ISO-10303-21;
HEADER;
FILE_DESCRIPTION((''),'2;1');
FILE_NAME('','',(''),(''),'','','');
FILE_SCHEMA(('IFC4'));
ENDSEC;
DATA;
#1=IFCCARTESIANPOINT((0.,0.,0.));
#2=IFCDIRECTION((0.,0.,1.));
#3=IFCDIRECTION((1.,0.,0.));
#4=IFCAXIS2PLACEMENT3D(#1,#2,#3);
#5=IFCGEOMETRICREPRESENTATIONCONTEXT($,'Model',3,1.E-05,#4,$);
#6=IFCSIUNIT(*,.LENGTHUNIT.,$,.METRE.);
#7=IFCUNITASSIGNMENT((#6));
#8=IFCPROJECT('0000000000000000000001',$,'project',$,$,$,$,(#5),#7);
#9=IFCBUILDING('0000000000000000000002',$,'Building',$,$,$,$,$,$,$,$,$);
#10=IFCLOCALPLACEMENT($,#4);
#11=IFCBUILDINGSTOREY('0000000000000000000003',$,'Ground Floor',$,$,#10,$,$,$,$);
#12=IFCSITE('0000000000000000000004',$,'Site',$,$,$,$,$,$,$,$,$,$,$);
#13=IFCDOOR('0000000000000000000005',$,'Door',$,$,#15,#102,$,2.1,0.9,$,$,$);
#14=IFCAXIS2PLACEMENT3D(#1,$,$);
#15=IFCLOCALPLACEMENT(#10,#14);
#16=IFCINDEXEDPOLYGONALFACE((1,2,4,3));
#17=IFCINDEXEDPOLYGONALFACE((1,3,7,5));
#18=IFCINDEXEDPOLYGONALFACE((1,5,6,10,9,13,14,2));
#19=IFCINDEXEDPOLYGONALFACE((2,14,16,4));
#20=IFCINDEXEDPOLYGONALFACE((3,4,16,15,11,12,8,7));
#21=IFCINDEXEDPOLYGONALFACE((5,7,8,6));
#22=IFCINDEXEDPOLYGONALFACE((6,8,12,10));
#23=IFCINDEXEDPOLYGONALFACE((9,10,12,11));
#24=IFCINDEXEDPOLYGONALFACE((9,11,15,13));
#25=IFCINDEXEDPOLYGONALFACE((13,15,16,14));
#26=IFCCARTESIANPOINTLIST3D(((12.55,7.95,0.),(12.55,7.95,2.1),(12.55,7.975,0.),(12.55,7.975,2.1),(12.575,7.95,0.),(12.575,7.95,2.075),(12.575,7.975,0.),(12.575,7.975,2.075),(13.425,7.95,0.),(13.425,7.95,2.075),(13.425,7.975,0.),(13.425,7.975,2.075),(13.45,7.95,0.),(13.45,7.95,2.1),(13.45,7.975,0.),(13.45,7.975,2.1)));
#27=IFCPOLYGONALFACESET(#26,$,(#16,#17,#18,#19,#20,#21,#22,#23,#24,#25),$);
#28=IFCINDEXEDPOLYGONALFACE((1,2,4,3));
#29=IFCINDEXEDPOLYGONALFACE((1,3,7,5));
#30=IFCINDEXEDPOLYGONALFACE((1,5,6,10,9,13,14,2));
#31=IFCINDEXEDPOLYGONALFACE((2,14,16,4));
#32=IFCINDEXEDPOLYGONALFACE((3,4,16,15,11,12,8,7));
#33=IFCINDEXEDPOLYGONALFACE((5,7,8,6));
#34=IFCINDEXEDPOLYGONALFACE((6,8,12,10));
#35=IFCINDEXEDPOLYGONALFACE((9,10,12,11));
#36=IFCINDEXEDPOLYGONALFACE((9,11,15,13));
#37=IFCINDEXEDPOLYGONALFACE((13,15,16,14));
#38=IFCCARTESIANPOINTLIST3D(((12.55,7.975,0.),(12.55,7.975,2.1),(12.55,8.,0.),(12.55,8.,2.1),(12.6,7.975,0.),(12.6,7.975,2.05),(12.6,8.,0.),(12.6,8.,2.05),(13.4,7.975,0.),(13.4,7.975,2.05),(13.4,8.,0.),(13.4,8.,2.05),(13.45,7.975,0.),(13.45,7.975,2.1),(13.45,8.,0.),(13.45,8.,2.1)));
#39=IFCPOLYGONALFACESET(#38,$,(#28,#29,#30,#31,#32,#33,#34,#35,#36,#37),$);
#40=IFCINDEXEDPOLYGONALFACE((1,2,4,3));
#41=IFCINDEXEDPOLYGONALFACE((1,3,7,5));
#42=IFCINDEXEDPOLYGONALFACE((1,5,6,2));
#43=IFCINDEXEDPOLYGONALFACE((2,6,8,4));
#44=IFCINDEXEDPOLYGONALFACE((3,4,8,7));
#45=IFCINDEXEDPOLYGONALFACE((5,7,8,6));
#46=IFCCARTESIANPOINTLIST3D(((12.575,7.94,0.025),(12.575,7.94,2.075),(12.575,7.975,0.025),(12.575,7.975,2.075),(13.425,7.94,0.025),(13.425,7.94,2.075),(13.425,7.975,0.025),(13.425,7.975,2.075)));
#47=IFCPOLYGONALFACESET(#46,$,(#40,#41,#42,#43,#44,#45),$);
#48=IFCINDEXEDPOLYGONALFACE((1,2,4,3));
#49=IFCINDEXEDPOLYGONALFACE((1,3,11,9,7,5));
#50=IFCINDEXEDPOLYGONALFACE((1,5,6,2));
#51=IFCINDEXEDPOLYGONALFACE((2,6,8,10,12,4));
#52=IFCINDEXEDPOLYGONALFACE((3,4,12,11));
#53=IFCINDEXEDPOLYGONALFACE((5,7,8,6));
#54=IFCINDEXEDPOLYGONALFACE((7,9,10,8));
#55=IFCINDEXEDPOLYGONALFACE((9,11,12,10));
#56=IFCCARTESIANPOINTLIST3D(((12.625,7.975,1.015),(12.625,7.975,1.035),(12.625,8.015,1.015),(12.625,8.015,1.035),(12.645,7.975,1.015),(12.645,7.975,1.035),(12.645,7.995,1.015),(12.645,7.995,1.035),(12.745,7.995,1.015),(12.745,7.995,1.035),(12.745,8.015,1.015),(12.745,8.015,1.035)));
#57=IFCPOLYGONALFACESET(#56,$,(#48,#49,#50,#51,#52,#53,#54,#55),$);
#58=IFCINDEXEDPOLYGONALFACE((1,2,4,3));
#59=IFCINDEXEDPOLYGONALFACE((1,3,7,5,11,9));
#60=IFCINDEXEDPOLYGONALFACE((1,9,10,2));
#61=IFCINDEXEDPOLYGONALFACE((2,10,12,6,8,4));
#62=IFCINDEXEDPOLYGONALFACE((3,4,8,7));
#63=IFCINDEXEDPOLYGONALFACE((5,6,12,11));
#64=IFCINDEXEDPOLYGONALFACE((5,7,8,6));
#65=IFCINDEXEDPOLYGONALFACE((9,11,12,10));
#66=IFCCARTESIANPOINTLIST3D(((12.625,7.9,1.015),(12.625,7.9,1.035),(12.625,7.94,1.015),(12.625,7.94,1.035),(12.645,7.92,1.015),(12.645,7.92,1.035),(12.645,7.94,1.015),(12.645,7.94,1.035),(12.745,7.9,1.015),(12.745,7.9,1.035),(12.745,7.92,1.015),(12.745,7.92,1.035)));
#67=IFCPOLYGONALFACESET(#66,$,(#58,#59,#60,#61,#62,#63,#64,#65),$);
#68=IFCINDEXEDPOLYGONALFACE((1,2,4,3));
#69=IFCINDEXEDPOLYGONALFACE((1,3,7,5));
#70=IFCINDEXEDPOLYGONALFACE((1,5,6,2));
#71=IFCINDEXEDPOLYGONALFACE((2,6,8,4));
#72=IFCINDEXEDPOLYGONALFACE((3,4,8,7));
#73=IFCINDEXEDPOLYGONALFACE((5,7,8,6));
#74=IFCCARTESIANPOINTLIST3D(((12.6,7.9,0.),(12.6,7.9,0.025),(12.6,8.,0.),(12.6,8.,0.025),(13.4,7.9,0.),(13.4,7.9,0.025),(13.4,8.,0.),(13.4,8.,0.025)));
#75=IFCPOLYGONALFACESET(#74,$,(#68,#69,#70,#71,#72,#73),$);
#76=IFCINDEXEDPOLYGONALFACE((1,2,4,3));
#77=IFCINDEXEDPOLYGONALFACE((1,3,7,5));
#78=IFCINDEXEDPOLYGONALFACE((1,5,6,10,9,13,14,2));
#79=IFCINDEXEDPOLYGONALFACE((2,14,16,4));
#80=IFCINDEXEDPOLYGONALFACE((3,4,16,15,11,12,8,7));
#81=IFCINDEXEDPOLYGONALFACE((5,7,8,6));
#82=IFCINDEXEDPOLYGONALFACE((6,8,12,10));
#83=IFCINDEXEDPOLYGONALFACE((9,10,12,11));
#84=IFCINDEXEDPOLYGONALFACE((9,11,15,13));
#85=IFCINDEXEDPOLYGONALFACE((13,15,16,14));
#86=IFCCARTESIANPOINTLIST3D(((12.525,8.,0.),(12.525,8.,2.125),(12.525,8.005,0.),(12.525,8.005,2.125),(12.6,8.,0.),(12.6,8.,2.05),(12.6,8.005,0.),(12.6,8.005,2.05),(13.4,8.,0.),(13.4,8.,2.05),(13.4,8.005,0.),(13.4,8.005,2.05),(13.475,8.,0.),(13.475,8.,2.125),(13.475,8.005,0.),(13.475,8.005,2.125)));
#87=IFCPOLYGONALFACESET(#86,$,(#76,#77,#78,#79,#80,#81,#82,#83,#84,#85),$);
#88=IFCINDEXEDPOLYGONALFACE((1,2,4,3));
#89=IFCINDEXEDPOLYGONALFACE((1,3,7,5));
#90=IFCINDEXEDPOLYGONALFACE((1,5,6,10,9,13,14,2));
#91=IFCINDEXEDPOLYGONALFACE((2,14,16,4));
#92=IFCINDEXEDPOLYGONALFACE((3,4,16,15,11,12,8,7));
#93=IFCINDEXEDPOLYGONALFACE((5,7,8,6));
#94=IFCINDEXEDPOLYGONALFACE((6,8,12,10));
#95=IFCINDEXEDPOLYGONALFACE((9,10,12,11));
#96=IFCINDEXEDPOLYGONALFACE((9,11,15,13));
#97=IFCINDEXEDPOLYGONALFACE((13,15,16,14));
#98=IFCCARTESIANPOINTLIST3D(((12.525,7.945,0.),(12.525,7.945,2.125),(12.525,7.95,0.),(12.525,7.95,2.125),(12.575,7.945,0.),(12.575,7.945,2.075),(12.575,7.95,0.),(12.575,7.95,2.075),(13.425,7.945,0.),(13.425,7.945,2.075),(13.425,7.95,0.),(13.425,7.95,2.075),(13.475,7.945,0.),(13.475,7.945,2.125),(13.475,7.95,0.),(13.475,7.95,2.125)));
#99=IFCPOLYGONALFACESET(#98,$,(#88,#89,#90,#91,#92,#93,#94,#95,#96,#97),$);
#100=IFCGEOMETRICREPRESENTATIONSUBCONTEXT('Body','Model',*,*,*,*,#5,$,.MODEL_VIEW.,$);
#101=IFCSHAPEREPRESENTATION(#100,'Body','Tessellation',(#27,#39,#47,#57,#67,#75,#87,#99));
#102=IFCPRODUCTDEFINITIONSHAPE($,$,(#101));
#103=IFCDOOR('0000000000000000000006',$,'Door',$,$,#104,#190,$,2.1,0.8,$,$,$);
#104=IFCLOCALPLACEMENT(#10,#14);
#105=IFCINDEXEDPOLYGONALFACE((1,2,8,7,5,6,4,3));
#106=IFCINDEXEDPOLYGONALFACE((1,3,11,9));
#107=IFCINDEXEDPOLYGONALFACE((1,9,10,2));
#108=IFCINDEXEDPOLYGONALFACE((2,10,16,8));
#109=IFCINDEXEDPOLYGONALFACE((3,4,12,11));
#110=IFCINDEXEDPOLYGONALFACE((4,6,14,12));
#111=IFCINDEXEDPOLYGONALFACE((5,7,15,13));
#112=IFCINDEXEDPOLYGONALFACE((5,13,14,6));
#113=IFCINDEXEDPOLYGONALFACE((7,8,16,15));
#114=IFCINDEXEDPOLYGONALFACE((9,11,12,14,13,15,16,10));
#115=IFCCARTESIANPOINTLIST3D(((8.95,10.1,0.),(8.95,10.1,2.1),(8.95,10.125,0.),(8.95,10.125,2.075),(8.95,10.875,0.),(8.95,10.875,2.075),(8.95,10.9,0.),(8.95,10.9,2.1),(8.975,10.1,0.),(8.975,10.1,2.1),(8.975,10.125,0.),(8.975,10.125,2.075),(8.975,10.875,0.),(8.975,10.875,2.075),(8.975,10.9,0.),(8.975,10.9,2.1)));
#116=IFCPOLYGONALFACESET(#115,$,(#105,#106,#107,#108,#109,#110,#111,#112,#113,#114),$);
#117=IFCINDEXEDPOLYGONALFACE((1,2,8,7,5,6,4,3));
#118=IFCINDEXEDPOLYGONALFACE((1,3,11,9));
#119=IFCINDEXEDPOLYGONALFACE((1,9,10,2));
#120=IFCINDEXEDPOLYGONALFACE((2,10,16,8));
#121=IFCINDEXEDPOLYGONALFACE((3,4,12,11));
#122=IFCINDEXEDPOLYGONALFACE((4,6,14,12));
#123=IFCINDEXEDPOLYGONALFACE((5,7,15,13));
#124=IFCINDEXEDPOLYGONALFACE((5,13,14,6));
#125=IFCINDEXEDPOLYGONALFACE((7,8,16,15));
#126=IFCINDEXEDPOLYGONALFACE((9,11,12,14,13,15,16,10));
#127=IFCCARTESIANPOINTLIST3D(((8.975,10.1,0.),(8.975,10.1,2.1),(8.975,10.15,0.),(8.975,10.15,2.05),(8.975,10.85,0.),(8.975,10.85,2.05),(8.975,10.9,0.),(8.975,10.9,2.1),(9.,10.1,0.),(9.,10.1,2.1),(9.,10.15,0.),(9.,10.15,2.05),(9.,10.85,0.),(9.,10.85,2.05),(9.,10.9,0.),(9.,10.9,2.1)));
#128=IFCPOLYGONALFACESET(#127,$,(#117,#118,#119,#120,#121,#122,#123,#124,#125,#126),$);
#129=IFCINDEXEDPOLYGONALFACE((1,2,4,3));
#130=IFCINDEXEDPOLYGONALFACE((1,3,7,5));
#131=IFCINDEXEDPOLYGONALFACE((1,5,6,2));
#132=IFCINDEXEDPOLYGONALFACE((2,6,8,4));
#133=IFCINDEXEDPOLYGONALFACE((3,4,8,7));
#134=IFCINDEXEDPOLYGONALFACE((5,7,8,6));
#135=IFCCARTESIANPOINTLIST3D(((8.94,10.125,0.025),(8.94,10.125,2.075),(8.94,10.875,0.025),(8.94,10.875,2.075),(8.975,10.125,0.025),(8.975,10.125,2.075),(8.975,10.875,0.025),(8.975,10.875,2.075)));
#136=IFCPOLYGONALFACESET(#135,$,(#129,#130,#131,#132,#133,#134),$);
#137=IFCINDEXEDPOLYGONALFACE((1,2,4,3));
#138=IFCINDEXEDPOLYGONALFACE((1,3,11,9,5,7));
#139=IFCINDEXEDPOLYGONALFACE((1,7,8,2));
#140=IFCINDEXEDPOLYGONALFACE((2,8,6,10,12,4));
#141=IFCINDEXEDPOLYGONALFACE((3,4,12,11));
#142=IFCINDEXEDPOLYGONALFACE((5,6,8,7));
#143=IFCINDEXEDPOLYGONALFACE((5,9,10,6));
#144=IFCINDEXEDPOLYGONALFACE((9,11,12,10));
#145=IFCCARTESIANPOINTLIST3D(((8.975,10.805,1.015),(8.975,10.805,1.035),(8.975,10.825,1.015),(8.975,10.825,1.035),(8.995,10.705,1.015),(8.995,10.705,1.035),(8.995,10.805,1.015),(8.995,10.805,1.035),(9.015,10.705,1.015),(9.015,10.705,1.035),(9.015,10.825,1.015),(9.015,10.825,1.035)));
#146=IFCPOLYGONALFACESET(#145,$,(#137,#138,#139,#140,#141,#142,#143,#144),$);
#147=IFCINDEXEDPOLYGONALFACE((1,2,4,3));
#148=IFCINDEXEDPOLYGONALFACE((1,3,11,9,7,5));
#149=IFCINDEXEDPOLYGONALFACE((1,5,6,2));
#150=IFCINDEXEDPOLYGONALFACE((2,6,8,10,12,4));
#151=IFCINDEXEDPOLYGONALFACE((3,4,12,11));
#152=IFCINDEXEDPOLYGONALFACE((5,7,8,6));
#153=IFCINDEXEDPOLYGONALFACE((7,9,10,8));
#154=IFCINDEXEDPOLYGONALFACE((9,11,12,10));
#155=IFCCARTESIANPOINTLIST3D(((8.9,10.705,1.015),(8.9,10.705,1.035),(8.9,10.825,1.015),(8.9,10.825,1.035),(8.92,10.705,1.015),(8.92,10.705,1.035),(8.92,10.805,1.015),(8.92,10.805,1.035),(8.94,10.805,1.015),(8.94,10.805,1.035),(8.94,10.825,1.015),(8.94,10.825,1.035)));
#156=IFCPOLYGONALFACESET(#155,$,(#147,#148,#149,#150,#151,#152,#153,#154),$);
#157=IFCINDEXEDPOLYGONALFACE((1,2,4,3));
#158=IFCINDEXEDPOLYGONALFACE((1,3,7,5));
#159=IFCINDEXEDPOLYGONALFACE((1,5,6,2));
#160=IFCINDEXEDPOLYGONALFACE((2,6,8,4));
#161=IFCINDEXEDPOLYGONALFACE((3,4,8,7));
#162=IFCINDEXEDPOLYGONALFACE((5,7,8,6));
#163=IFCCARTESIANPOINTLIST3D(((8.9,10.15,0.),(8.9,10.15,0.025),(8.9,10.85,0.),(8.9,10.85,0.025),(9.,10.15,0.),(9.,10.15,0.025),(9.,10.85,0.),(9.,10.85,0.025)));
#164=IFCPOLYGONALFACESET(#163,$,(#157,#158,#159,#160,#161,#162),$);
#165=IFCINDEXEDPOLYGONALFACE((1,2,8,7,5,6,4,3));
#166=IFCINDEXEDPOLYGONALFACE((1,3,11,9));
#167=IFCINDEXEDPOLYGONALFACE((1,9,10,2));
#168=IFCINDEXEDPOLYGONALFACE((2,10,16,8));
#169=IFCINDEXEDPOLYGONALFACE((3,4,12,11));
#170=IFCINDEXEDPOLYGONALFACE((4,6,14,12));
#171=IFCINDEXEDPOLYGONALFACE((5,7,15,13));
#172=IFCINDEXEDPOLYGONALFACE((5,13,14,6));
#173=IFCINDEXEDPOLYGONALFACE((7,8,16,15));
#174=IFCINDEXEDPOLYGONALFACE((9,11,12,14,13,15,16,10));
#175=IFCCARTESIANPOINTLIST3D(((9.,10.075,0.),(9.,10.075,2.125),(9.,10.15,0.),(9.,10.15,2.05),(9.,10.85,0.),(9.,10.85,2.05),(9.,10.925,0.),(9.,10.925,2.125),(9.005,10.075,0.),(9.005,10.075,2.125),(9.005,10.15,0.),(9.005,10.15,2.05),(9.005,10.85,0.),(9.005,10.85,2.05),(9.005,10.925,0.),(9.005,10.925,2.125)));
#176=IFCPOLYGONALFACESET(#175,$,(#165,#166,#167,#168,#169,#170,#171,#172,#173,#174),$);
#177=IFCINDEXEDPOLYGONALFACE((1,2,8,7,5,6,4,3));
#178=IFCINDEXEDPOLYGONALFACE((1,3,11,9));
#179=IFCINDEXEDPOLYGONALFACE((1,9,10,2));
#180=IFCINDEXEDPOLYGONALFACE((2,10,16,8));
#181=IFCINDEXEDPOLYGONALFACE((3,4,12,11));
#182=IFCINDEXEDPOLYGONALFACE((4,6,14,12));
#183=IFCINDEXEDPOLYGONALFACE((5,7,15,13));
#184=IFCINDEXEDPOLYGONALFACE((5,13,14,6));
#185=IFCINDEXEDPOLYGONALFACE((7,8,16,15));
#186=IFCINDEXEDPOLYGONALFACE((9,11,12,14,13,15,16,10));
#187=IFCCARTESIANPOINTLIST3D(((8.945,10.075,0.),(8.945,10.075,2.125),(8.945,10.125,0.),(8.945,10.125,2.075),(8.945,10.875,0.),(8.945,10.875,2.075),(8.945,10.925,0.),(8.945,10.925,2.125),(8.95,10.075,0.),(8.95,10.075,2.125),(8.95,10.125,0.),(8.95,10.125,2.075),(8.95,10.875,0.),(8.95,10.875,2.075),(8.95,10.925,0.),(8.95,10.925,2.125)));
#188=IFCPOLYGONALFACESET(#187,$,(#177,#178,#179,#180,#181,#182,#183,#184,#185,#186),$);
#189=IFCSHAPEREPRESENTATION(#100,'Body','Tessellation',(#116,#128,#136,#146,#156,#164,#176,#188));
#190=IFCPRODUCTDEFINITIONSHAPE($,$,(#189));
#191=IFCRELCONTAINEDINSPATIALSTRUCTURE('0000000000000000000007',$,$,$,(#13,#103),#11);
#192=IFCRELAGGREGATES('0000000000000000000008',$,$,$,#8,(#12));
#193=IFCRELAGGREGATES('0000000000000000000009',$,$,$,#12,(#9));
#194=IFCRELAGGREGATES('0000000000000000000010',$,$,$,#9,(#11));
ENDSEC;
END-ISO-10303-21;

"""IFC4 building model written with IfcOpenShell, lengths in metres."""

from ifc_helpers import new_model, si_unit, frame, origin_with_axes, place, context, subcontext, project, spatial, line, indexed_curve, outline, extrude, element, save


model = new_model("IFC4")

# Units and contexts
model_context = context("Model", 3, precision=1e-05, world=origin_with_axes())
body_context = subcontext(model_context, "Body", "Model", "MODEL_VIEW")
ifc_project = project(units=[si_unit("LENGTHUNIT", "METRE")], contexts=[model_context])

# Site, building, storey
site = spatial("IfcSite", under=ifc_project, Name="Site")
building = spatial("IfcBuilding", under=site, Name="Building")
storey_placement = place(None, origin_with_axes())
storey = spatial("IfcBuildingStorey", under=building, at=storey_placement, Name="Ground Floor")

# Doors
door_1_placement = place(storey_placement, frame((13.45, 8.0, 0.0), z_axis=(0.0, 0.0, 1.0), x_axis=(-1.0, 0.0, 0.0)))
element("IfcDoor", 1, at=door_1_placement, inside=storey, Name="Door", OverallHeight=2.1, OverallWidth=0.9, context=body_context, shape_type="SweptSolid", body=[
    extrude(outline(indexed_curve([(0.0, 0.0), (0.0, 2.1), (0.9, 2.1), (0.9, 0.0), (0.875, 0.0), (0.875, 2.075), (0.025, 2.075), (0.025, 0.0)], segments=[line(1, 2, 3, 4, 5, 6, 7, 8, 1)])), frame((0.0, 0.025, 0.0), z_axis=(0.0, -1.0, 0.0), x_axis=(1.0, 0.0, 0.0)), (0.0, 0.0, -1.0), 0.025),
    extrude(outline(indexed_curve([(0.0, 0.0), (0.0, 2.1), (0.9, 2.1), (0.9, 0.0), (0.85, 0.0), (0.85, 2.05), (0.05, 2.05), (0.05, 0.0)], segments=[line(1, 2, 3, 4, 5, 6, 7, 8, 1)])), frame((0.0, 0.0, 0.0), z_axis=(0.0, -1.0, 0.0), x_axis=(1.0, 0.0, 0.0)), (0.0, 0.0, -1.0), 0.025),
    extrude(outline(indexed_curve([(0.0, 0.0), (0.85, 0.0), (0.85, 0.035), (0.0, 0.035)], segments=[line(1, 2, 3, 4, 1)])), frame((0.025, 0.025, 0.025), z_axis=(0.0, 0.0, 1.0), x_axis=(1.0, 0.0, 0.0)), (0.0, 0.0, 1.0), 2.05),
    extrude(outline(indexed_curve([(0.0, 0.0), (0.0, -0.04), (-0.12, -0.04), (-0.12, -0.02), (-0.02, -0.02), (-0.02, 0.0)], segments=[line(1, 2, 3, 4, 5, 6, 1)])), frame((0.825, 0.025, 1.015), z_axis=(0.0, 0.0, 1.0), x_axis=(1.0, 0.0, 0.0)), (0.0, 0.0, 1.0), 0.02),
    extrude(outline(indexed_curve([(0.0, 0.0), (0.0, 0.04), (-0.12, 0.04), (-0.12, 0.02), (-0.02, 0.02), (-0.02, 0.0)], segments=[line(1, 2, 3, 4, 5, 6, 1)])), frame((0.825, 0.06, 1.015), z_axis=(0.0, 0.0, 1.0), x_axis=(1.0, 0.0, 0.0)), (0.0, 0.0, 1.0), 0.02),
    extrude(outline(indexed_curve([(0.0, 0.0), (0.8, 0.0), (0.8, 0.1), (0.0, 0.1)], segments=[line(1, 2, 3, 4, 1)])), frame((0.05, 0.0, 0.0), z_axis=(0.0, 0.0, 1.0), x_axis=(1.0, 0.0, 0.0)), (0.0, 0.0, 1.0), 0.025),
    extrude(outline(indexed_curve([(0.0, 0.0), (0.0, 2.125), (0.95, 2.125), (0.95, 0.0), (0.875, 0.0), (0.875, 2.05), (0.075, 2.05), (0.075, 0.0)], segments=[line(1, 2, 3, 4, 5, 6, 7, 8, 1)])), frame((-0.025, -0.005, 0.0), z_axis=(0.0, -1.0, 0.0), x_axis=(1.0, 0.0, 0.0)), (0.0, 0.0, -1.0), 0.005),
    extrude(outline(indexed_curve([(0.0, 0.0), (0.0, 2.125), (0.95, 2.125), (0.95, 0.0), (0.9, 0.0), (0.9, 2.075), (0.05, 2.075), (0.05, 0.0)], segments=[line(1, 2, 3, 4, 5, 6, 7, 8, 1)])), frame((-0.025, 0.05, 0.0), z_axis=(0.0, -1.0, 0.0), x_axis=(1.0, 0.0, 0.0)), (0.0, 0.0, -1.0), 0.005),
])
door_2_placement = place(storey_placement, frame((9.0, 10.1, 0.0), z_axis=(0.0, 0.0, 1.0), x_axis=(0.0, 1.0, 0.0)))
element("IfcDoor", 2, at=door_2_placement, inside=storey, Name="Door", OverallHeight=2.1, OverallWidth=0.8, context=body_context, shape_type="SweptSolid", body=[
    extrude(outline(indexed_curve([(0.0, 0.0), (0.0, 2.1), (0.8, 2.1), (0.8, 0.0), (0.775, 0.0), (0.775, 2.075), (0.025, 2.075), (0.025, 0.0)], segments=[line(1, 2, 3, 4, 5, 6, 7, 8, 1)])), frame((0.0, 0.025, 0.0), z_axis=(0.0, -1.0, 0.0), x_axis=(1.0, 0.0, 0.0)), (0.0, 0.0, -1.0), 0.025),
    extrude(outline(indexed_curve([(0.0, 0.0), (0.0, 2.1), (0.8, 2.1), (0.8, 0.0), (0.75, 0.0), (0.75, 2.05), (0.05, 2.05), (0.05, 0.0)], segments=[line(1, 2, 3, 4, 5, 6, 7, 8, 1)])), frame((0.0, 0.0, 0.0), z_axis=(0.0, -1.0, 0.0), x_axis=(1.0, 0.0, 0.0)), (0.0, 0.0, -1.0), 0.025),
    extrude(outline(indexed_curve([(0.0, 0.0), (0.75, 0.0), (0.75, 0.035), (0.0, 0.035)], segments=[line(1, 2, 3, 4, 1)])), frame((0.025, 0.025, 0.025), z_axis=(0.0, 0.0, 1.0), x_axis=(1.0, 0.0, 0.0)), (0.0, 0.0, 1.0), 2.05),
    extrude(outline(indexed_curve([(0.0, 0.0), (0.0, -0.04), (-0.12, -0.04), (-0.12, -0.02), (-0.02, -0.02), (-0.02, 0.0)], segments=[line(1, 2, 3, 4, 5, 6, 1)])), frame((0.725, 0.025, 1.015), z_axis=(0.0, 0.0, 1.0), x_axis=(1.0, 0.0, 0.0)), (0.0, 0.0, 1.0), 0.02),
    extrude(outline(indexed_curve([(0.0, 0.0), (0.0, 0.04), (-0.12, 0.04), (-0.12, 0.02), (-0.02, 0.02), (-0.02, 0.0)], segments=[line(1, 2, 3, 4, 5, 6, 1)])), frame((0.725, 0.06, 1.015), z_axis=(0.0, 0.0, 1.0), x_axis=(1.0, 0.0, 0.0)), (0.0, 0.0, 1.0), 0.02),
    extrude(outline(indexed_curve([(0.0, 0.0), (0.7, 0.0), (0.7, 0.1), (0.0, 0.1)], segments=[line(1, 2, 3, 4, 1)])), frame((0.05, 0.0, 0.0), z_axis=(0.0, 0.0, 1.0), x_axis=(1.0, 0.0, 0.0)), (0.0, 0.0, 1.0), 0.025),
    extrude(outline(indexed_curve([(0.0, 0.0), (0.0, 2.125), (0.85, 2.125), (0.85, 0.0), (0.775, 0.0), (0.775, 2.05), (0.075, 2.05), (0.075, 0.0)], segments=[line(1, 2, 3, 4, 5, 6, 7, 8, 1)])), frame((-0.025, -0.005, 0.0), z_axis=(0.0, -1.0, 0.0), x_axis=(1.0, 0.0, 0.0)), (0.0, 0.0, -1.0), 0.005),
    extrude(outline(indexed_curve([(0.0, 0.0), (0.0, 2.125), (0.85, 2.125), (0.85, 0.0), (0.8, 0.0), (0.8, 2.075), (0.05, 2.075), (0.05, 0.0)], segments=[line(1, 2, 3, 4, 5, 6, 7, 8, 1)])), frame((-0.025, 0.05, 0.0), z_axis=(0.0, -1.0, 0.0), x_axis=(1.0, 0.0, 0.0)), (0.0, 0.0, -1.0), 0.005),
])

save(model, "model.ifc")
